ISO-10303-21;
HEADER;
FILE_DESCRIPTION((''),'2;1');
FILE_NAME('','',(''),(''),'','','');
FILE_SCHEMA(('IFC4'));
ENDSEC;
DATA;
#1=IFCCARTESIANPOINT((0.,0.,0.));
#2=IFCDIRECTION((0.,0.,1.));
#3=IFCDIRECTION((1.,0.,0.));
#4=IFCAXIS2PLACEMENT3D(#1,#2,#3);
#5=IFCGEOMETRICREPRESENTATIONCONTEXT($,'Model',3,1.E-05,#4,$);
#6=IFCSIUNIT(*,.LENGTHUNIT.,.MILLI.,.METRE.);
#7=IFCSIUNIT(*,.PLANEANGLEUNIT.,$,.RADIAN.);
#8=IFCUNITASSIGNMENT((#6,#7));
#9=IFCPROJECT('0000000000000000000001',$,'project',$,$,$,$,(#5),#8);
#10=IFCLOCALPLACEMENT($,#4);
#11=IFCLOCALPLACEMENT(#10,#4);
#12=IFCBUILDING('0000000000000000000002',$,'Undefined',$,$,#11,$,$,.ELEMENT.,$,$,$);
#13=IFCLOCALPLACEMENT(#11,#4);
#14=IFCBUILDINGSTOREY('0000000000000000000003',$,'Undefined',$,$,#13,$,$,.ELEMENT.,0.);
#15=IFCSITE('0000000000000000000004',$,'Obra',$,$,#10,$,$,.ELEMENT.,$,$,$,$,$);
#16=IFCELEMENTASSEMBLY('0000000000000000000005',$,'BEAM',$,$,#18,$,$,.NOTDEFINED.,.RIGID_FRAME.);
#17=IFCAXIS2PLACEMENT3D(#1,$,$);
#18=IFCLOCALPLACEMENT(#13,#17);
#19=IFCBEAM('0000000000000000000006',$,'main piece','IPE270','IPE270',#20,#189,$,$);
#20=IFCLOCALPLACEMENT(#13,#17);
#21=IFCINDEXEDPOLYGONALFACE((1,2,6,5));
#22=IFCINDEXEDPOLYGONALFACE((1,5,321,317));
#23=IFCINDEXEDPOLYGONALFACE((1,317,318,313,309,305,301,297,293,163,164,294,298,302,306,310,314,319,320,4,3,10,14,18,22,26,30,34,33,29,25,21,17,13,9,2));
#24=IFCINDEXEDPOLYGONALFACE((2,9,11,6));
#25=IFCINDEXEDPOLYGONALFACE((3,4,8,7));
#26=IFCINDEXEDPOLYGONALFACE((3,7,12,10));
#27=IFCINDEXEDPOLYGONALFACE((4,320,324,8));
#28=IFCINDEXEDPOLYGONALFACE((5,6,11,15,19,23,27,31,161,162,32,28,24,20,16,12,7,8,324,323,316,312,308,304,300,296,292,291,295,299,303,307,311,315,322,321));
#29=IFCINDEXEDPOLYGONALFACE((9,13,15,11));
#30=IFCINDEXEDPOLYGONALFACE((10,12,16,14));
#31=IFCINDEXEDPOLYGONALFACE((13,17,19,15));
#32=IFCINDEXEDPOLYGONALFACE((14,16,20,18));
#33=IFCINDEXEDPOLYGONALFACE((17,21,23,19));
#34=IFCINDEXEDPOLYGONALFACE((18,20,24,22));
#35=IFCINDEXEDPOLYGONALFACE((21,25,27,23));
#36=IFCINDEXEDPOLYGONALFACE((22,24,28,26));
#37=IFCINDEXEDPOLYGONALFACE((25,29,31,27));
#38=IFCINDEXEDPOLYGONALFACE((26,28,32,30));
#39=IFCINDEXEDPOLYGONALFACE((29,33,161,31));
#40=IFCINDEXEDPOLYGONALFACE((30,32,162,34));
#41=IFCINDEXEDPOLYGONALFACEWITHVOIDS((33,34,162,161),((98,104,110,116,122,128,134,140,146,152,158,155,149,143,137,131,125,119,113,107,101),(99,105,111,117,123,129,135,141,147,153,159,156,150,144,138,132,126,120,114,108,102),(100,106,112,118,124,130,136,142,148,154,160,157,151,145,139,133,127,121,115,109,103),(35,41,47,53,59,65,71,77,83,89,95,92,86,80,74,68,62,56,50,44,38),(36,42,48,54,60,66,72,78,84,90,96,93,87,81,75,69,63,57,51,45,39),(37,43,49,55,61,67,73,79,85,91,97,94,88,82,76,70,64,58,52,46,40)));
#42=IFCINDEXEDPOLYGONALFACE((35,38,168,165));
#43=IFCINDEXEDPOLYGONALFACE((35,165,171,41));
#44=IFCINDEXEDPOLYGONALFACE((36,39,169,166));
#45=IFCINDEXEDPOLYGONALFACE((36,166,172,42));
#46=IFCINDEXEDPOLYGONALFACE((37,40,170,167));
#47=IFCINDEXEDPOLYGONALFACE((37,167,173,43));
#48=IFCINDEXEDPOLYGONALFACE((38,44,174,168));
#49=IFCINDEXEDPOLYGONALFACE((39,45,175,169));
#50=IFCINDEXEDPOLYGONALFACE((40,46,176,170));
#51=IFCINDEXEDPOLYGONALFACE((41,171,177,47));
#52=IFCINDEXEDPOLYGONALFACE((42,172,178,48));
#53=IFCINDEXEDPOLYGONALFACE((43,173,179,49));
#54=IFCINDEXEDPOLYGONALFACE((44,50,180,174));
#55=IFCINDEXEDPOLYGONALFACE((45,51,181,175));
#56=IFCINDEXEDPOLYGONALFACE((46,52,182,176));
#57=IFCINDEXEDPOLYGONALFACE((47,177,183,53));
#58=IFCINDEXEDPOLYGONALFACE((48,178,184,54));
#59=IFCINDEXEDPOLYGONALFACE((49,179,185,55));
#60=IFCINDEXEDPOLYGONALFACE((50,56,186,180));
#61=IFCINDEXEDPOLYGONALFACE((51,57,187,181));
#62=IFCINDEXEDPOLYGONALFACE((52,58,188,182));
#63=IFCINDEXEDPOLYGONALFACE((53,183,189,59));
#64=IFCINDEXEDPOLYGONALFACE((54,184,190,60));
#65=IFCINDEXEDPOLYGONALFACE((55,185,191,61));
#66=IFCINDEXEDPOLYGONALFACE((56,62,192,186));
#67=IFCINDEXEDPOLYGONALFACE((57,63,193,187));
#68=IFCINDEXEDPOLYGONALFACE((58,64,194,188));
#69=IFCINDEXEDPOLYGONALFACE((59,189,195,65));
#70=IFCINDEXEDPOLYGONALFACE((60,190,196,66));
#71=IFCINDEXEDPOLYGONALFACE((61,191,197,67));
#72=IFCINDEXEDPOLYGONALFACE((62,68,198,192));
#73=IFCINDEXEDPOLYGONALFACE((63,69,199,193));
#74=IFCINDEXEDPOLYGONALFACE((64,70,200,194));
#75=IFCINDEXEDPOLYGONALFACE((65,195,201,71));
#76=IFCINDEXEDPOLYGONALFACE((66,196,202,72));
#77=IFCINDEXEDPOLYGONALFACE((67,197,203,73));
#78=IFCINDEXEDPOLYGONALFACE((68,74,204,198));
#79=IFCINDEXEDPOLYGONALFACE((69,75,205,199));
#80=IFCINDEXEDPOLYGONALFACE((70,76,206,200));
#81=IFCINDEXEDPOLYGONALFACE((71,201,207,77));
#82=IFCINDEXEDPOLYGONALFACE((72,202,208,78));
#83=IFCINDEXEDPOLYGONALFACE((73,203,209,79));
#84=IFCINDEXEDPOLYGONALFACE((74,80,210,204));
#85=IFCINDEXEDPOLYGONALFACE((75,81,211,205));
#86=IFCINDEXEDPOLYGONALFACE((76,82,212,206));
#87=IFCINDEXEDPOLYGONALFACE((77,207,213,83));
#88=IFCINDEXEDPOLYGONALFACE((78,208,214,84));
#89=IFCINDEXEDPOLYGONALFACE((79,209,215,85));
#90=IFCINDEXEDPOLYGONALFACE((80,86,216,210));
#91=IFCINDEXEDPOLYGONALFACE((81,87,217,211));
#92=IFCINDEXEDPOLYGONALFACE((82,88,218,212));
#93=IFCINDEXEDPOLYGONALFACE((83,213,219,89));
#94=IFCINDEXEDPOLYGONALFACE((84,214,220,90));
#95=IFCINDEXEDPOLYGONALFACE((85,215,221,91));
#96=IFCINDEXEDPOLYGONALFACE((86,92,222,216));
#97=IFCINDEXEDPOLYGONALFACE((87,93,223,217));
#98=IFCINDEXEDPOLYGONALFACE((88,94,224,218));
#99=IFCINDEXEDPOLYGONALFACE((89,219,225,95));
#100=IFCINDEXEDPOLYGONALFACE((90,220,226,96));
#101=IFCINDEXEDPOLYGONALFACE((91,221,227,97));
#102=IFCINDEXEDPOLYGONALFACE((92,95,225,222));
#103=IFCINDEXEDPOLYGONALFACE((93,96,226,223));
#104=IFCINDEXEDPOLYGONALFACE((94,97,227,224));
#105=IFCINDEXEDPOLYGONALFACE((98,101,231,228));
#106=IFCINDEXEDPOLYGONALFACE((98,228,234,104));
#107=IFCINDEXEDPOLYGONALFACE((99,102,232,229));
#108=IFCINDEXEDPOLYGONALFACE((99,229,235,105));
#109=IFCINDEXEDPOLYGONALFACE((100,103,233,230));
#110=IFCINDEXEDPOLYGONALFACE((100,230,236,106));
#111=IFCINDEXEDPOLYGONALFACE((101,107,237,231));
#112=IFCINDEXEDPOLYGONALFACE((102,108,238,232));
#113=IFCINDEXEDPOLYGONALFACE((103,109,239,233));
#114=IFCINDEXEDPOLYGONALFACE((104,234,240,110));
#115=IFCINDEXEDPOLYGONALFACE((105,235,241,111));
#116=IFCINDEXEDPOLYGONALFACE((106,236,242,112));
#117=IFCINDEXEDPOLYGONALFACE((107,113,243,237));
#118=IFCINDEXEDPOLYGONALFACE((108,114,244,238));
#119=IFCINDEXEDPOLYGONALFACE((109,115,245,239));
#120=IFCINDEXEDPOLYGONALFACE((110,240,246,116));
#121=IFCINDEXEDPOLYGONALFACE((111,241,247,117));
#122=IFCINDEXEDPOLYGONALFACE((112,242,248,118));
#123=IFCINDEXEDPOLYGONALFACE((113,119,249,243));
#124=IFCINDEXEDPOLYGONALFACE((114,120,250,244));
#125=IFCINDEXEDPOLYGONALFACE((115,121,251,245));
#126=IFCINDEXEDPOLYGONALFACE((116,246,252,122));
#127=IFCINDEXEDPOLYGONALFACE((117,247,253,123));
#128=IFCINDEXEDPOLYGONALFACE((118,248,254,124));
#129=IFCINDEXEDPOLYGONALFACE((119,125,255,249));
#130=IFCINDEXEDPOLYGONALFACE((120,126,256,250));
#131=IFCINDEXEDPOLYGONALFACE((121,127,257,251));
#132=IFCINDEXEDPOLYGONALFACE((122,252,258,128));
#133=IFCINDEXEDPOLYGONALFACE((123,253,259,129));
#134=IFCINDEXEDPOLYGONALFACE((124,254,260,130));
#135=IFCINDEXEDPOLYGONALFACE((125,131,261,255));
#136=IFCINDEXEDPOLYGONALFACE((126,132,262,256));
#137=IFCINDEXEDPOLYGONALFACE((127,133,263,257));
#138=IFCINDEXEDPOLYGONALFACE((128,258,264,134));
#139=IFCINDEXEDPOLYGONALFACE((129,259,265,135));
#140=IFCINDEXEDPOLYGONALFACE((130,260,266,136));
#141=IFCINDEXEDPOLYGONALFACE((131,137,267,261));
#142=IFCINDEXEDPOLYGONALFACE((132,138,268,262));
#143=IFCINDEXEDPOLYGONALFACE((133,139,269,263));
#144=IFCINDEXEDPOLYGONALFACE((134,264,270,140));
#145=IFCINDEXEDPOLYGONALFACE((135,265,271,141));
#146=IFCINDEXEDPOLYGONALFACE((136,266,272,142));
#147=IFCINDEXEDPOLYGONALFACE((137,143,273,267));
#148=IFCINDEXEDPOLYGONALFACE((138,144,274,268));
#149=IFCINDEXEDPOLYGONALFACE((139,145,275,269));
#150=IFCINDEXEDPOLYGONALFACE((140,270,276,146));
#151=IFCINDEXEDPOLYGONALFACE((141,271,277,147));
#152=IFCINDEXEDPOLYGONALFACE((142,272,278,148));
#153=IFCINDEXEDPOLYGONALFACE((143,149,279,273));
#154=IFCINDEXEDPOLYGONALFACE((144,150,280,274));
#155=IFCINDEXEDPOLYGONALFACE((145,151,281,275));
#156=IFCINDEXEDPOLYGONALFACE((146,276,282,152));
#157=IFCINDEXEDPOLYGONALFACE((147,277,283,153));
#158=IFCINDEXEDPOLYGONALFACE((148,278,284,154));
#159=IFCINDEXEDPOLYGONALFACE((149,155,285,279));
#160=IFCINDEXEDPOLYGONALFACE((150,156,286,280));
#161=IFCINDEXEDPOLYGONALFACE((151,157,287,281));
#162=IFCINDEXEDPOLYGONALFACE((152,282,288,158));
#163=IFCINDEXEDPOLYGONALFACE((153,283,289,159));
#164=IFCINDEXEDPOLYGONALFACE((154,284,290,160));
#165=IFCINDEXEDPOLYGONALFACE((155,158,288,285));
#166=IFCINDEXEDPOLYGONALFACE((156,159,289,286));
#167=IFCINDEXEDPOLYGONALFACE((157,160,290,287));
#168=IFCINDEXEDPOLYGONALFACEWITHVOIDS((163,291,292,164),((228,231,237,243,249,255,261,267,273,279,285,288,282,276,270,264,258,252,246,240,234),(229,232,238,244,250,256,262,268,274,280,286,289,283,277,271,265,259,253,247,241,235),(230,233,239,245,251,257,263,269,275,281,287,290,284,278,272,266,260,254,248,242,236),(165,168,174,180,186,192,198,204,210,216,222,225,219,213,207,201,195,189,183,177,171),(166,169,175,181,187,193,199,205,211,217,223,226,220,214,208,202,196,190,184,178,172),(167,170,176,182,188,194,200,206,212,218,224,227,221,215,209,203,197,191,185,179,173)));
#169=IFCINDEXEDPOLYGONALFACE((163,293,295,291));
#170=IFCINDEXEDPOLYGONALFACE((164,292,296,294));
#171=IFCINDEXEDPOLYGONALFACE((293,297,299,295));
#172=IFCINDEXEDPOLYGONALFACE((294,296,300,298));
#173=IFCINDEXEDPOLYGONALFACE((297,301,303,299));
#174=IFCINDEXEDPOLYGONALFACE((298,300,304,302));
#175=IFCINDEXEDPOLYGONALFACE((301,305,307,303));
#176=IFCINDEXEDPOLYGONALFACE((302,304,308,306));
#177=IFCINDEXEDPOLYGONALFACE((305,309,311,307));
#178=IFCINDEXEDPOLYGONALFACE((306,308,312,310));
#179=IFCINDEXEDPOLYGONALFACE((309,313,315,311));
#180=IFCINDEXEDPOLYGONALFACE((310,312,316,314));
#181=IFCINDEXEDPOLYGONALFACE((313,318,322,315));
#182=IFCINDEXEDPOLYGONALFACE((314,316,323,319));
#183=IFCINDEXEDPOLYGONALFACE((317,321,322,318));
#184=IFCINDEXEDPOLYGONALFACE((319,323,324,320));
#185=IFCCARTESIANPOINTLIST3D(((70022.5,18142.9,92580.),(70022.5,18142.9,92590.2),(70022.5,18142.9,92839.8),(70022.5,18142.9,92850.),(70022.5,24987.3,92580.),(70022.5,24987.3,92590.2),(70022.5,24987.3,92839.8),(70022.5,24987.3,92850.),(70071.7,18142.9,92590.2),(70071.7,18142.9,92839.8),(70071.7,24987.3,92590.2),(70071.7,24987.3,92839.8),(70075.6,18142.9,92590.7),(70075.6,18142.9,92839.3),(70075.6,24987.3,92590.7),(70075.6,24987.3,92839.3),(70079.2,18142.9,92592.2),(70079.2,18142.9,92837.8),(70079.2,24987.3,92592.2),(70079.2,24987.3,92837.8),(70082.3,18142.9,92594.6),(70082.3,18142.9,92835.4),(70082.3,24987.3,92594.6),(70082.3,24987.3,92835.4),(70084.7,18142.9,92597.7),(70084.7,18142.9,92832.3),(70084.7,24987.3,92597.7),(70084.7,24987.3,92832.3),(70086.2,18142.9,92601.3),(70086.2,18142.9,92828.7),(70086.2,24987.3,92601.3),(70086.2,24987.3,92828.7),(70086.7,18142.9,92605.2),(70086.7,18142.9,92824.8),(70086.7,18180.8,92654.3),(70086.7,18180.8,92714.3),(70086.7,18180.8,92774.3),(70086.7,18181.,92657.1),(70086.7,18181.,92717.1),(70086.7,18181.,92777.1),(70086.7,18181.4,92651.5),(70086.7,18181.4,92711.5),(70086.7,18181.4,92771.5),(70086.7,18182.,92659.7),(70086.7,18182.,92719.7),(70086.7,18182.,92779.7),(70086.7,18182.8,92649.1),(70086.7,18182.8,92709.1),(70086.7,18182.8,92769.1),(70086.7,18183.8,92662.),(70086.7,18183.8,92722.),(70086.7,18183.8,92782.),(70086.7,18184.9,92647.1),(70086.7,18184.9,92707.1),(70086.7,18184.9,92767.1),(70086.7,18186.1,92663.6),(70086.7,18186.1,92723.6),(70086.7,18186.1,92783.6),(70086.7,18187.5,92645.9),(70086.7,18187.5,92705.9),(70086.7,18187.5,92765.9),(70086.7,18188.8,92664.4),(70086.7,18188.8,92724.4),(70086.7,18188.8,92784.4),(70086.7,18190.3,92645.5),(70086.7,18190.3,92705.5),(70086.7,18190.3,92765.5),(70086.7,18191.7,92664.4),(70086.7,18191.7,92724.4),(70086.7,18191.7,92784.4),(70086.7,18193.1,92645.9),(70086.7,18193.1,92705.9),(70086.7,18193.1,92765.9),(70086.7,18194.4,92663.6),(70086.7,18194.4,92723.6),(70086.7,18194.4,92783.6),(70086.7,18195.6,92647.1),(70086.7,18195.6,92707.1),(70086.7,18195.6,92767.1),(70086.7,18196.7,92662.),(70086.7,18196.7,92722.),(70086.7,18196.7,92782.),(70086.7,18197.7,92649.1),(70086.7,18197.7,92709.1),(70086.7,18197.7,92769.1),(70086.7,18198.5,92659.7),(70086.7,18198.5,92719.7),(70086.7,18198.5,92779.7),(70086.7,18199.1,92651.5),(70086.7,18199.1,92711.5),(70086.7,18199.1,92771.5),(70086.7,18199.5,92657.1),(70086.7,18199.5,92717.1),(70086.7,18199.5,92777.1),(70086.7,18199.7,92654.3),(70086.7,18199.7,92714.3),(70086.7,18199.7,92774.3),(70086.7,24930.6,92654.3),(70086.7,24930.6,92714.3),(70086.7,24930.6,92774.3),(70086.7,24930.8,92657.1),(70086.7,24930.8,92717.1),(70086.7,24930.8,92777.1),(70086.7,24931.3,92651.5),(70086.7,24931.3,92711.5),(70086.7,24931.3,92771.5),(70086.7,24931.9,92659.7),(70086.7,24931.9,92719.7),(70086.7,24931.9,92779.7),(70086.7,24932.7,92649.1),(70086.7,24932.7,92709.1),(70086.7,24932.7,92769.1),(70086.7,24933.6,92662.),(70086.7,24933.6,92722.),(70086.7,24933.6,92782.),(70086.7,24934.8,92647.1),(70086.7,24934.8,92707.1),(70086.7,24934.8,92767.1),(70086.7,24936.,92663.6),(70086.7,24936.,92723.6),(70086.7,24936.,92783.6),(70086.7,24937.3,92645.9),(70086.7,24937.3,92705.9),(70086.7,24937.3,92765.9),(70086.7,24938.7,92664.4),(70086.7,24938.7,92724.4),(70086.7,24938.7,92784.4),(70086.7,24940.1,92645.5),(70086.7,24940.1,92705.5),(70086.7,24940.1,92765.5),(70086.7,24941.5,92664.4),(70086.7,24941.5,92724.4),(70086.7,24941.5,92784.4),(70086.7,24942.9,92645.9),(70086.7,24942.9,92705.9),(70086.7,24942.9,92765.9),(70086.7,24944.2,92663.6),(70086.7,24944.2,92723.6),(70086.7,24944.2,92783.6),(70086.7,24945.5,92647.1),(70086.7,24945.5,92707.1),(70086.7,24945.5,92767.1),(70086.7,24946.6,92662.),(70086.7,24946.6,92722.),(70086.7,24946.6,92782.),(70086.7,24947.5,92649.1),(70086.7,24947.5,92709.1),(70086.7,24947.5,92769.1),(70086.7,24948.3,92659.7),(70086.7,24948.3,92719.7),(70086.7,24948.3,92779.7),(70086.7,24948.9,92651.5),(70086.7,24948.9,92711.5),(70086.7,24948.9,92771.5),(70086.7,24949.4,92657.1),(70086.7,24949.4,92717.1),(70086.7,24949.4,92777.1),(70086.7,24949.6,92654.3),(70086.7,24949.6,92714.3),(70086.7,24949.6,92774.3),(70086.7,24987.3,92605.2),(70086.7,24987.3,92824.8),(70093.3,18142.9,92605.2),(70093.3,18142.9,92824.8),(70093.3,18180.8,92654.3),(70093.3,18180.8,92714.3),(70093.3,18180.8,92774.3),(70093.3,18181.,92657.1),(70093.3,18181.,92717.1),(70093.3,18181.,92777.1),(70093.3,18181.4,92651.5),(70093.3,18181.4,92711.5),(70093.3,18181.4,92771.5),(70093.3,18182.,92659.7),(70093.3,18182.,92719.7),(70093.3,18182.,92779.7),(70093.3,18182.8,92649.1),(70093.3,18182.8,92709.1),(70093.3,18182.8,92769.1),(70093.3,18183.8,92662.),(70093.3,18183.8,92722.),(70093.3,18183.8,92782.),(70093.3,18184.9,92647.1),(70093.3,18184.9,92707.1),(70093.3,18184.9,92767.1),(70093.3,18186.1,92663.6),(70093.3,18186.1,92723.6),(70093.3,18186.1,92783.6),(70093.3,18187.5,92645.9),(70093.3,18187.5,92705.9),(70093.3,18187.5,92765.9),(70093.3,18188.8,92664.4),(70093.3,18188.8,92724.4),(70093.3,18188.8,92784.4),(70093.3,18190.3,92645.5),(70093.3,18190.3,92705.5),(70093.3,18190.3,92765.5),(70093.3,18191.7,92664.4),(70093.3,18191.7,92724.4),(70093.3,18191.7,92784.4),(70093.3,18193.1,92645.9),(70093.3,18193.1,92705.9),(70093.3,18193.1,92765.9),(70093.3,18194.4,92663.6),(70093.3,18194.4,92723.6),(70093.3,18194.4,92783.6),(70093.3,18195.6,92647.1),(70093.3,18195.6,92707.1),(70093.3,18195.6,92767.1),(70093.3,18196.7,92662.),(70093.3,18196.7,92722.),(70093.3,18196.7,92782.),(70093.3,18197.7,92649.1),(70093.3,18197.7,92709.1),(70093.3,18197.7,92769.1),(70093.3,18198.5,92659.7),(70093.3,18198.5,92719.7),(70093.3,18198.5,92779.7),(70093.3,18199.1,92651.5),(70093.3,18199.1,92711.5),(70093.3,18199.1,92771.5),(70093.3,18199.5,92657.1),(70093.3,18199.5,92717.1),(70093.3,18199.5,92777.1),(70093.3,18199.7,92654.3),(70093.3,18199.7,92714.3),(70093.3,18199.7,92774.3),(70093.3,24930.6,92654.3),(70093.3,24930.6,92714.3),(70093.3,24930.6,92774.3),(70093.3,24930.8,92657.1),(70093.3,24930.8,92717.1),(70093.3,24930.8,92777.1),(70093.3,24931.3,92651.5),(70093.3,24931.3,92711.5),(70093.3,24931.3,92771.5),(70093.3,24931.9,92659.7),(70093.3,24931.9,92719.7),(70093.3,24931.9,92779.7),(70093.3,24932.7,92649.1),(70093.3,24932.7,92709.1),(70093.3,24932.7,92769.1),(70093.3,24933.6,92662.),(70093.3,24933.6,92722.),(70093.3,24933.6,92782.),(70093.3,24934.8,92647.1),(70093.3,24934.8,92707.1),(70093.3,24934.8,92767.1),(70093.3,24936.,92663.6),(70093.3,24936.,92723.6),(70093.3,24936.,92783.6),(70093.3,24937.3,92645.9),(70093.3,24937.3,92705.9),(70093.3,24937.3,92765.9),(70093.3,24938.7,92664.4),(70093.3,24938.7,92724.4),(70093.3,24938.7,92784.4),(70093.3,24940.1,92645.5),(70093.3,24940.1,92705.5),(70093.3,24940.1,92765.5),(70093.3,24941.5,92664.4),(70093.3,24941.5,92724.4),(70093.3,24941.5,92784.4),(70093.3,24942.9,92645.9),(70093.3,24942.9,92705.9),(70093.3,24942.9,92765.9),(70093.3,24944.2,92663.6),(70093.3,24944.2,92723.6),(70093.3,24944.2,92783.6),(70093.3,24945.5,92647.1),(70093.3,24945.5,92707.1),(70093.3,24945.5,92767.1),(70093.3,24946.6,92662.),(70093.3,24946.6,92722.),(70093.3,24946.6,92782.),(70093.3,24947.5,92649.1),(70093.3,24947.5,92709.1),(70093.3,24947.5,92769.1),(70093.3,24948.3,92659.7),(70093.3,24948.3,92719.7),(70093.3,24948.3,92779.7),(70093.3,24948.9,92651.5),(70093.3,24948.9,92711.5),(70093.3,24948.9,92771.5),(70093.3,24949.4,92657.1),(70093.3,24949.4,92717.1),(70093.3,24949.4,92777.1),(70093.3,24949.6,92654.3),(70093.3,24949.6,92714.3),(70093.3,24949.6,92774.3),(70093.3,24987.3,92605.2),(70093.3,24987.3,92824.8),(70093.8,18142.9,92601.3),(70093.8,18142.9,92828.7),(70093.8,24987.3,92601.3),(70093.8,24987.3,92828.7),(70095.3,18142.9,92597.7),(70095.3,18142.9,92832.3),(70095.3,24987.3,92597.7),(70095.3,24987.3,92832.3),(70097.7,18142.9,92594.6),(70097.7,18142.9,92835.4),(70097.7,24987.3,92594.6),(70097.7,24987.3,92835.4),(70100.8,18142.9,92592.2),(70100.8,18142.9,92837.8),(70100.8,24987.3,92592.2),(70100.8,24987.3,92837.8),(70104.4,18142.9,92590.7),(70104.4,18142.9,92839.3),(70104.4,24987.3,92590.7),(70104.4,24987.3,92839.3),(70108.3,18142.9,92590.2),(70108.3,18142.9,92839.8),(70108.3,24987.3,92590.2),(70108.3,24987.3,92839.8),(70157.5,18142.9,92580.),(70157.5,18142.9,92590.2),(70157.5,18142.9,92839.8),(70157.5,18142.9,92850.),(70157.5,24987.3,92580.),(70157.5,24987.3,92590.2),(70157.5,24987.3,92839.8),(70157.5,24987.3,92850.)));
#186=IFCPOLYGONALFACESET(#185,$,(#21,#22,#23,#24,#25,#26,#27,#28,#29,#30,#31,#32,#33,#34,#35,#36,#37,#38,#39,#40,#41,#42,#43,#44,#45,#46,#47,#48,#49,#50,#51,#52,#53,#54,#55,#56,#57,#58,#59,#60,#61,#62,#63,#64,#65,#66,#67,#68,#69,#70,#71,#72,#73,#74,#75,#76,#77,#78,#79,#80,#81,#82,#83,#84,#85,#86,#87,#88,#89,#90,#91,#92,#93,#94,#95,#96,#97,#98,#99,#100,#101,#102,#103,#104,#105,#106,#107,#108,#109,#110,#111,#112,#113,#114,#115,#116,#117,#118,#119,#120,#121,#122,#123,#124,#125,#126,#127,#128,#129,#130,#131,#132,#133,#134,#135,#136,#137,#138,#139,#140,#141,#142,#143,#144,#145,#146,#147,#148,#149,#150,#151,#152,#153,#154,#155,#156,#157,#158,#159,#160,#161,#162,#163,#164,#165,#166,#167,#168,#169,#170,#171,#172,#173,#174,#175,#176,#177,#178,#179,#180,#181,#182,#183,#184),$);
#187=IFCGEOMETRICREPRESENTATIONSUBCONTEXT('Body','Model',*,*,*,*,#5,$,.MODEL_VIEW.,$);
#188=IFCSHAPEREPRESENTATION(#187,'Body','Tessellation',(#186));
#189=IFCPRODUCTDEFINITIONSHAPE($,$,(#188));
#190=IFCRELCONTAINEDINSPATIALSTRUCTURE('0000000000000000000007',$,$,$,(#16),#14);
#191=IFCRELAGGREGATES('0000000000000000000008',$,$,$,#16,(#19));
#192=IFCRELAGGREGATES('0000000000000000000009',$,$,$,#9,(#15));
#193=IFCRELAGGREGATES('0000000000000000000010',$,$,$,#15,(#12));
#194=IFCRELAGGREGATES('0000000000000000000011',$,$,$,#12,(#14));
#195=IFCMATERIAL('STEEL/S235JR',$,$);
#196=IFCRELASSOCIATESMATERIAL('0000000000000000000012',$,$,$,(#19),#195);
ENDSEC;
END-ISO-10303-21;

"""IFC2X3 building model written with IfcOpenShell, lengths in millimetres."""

from ifc_helpers import new_model, si_unit, frame, origin_with_axes, origin_2d_with_axis, place, context, subcontext, project, spatial, circle, i_section, extrude, clip, halfspace, source, transform, mapped, material, element, aggregate, save


model = new_model("IFC2X3")

# Units and contexts
model_context = context("Model", 3, precision=1e-05, world=origin_with_axes())
body_context = subcontext(model_context, "Body", "Model", "MODEL_VIEW")
ifc_project = project(units=[si_unit("LENGTHUNIT", "METRE", prefix="MILLI"), si_unit("PLANEANGLEUNIT", "RADIAN")], contexts=[model_context])

# Site, building, storey
site_placement = place(None, origin_with_axes())
site = spatial("IfcSite", under=ifc_project, at=site_placement, Name="Obra", CompositionType="ELEMENT")
building_placement = place(site_placement, origin_with_axes())
building = spatial("IfcBuilding", under=site, at=building_placement, Name="Undefined", CompositionType="ELEMENT")
storey_placement = place(building_placement, origin_with_axes())
storey = spatial("IfcBuildingStorey", under=building, at=storey_placement, Name="Undefined", CompositionType="ELEMENT", Elevation=0.0)

# Shared definitions
ifc_material = material(Name="STEEL/S235JR")

# Element assembly, beam, openings
assembly_1_placement = place(storey_placement, origin_with_axes())
assembly_1 = element("IfcElementAssembly", 1, at=assembly_1_placement, inside=storey, Name="BEAM", AssemblyPlace="NOTDEFINED", PredefinedType="RIGID_FRAME")
beam_1_placement = place(assembly_1_placement, frame((70090.0, 18142.9, 92715.0), z_axis=(0.0, 0.0, 1.0), x_axis=(0.0, 1.0, 0.0)))
beam_1 = element("IfcBeam", 2, at=beam_1_placement, material=ifc_material, Name="main piece", Description="IPE270", ObjectType="IPE270", context=body_context, shape_type="Clipping", body=[
    clip(clip(extrude(i_section(OverallWidth=135.0, OverallDepth=270.0, WebThickness=6.6, FlangeThickness=10.2, FilletRadius=15.0, at=origin_2d_with_axis()), frame((6844.4, 0.0, 0.0), z_axis=(-1.0, 0.0, 0.0), x_axis=(0.0, -1.0, 0.0)), (0.0, 0.0, 1.0), 6844.4), halfspace(frame((6846.8, -60.0, -120.0), z_axis=(1.0, 0.000021, 0.0), x_axis=(0.0, 0.0, 1.0)), False)), halfspace(frame((-2.1, 60.0, -120.0), z_axis=(-1.0, -0.000019, 0.0), x_axis=(0.0, 0.0, 1.0)), False)),
])
shared_shape_1 = source(origin_with_axes(), body_context, "Body", "SweptSolid", [
    extrude(circle(Radius=9.5, at=origin_2d_with_axis()), frame((0.0, -3.4, 0.0), z_axis=(0.0, 1.0, 0.0), x_axis=(1.0, 0.0, 0.0)), (0.0, 0.0, 1.0), 6.8),
])
opening_1_placement = place(assembly_1_placement, frame((70090.0, 24990.1, 92835.0), z_axis=(0.000002, -1.0, 0.0), x_axis=(0.0, 0.0, -1.0)))
element("IfcOpeningElement", 3, at=opening_1_placement, cuts=beam_1, ObjectType="Opening", context=body_context, shape_type="MappedRepresentation", body=[
    mapped(shared_shape_1, transform((60.0, 0.0, 50.0))),
    mapped(shared_shape_1, transform((120.0, 0.0, 50.0))),
    mapped(shared_shape_1, transform((180.0, 0.0, 50.0))),
])
shared_shape_2 = source(origin_with_axes(), body_context, "Body", "SweptSolid", [
    extrude(circle(Radius=9.5, at=origin_2d_with_axis()), frame((0.0, -3.4, 0.0), z_axis=(0.0, 1.0, 0.0), x_axis=(1.0, 0.0, 0.0)), (0.0, 0.0, 1.0), 6.8),
])
opening_2_placement = place(assembly_1_placement, frame((70090.0, 18140.3, 92835.0), z_axis=(0.0, 1.0, 0.0), x_axis=(0.0, 0.0, -1.0)))
element("IfcOpeningElement", 4, at=opening_2_placement, cuts=beam_1, ObjectType="Opening", context=body_context, shape_type="MappedRepresentation", body=[
    mapped(shared_shape_2, transform((60.0, 0.0, 50.0))),
    mapped(shared_shape_2, transform((120.0, 0.0, 50.0))),
    mapped(shared_shape_2, transform((180.0, 0.0, 50.0))),
])
aggregate(assembly_1, [beam_1])

save(model, "model.ifc")
